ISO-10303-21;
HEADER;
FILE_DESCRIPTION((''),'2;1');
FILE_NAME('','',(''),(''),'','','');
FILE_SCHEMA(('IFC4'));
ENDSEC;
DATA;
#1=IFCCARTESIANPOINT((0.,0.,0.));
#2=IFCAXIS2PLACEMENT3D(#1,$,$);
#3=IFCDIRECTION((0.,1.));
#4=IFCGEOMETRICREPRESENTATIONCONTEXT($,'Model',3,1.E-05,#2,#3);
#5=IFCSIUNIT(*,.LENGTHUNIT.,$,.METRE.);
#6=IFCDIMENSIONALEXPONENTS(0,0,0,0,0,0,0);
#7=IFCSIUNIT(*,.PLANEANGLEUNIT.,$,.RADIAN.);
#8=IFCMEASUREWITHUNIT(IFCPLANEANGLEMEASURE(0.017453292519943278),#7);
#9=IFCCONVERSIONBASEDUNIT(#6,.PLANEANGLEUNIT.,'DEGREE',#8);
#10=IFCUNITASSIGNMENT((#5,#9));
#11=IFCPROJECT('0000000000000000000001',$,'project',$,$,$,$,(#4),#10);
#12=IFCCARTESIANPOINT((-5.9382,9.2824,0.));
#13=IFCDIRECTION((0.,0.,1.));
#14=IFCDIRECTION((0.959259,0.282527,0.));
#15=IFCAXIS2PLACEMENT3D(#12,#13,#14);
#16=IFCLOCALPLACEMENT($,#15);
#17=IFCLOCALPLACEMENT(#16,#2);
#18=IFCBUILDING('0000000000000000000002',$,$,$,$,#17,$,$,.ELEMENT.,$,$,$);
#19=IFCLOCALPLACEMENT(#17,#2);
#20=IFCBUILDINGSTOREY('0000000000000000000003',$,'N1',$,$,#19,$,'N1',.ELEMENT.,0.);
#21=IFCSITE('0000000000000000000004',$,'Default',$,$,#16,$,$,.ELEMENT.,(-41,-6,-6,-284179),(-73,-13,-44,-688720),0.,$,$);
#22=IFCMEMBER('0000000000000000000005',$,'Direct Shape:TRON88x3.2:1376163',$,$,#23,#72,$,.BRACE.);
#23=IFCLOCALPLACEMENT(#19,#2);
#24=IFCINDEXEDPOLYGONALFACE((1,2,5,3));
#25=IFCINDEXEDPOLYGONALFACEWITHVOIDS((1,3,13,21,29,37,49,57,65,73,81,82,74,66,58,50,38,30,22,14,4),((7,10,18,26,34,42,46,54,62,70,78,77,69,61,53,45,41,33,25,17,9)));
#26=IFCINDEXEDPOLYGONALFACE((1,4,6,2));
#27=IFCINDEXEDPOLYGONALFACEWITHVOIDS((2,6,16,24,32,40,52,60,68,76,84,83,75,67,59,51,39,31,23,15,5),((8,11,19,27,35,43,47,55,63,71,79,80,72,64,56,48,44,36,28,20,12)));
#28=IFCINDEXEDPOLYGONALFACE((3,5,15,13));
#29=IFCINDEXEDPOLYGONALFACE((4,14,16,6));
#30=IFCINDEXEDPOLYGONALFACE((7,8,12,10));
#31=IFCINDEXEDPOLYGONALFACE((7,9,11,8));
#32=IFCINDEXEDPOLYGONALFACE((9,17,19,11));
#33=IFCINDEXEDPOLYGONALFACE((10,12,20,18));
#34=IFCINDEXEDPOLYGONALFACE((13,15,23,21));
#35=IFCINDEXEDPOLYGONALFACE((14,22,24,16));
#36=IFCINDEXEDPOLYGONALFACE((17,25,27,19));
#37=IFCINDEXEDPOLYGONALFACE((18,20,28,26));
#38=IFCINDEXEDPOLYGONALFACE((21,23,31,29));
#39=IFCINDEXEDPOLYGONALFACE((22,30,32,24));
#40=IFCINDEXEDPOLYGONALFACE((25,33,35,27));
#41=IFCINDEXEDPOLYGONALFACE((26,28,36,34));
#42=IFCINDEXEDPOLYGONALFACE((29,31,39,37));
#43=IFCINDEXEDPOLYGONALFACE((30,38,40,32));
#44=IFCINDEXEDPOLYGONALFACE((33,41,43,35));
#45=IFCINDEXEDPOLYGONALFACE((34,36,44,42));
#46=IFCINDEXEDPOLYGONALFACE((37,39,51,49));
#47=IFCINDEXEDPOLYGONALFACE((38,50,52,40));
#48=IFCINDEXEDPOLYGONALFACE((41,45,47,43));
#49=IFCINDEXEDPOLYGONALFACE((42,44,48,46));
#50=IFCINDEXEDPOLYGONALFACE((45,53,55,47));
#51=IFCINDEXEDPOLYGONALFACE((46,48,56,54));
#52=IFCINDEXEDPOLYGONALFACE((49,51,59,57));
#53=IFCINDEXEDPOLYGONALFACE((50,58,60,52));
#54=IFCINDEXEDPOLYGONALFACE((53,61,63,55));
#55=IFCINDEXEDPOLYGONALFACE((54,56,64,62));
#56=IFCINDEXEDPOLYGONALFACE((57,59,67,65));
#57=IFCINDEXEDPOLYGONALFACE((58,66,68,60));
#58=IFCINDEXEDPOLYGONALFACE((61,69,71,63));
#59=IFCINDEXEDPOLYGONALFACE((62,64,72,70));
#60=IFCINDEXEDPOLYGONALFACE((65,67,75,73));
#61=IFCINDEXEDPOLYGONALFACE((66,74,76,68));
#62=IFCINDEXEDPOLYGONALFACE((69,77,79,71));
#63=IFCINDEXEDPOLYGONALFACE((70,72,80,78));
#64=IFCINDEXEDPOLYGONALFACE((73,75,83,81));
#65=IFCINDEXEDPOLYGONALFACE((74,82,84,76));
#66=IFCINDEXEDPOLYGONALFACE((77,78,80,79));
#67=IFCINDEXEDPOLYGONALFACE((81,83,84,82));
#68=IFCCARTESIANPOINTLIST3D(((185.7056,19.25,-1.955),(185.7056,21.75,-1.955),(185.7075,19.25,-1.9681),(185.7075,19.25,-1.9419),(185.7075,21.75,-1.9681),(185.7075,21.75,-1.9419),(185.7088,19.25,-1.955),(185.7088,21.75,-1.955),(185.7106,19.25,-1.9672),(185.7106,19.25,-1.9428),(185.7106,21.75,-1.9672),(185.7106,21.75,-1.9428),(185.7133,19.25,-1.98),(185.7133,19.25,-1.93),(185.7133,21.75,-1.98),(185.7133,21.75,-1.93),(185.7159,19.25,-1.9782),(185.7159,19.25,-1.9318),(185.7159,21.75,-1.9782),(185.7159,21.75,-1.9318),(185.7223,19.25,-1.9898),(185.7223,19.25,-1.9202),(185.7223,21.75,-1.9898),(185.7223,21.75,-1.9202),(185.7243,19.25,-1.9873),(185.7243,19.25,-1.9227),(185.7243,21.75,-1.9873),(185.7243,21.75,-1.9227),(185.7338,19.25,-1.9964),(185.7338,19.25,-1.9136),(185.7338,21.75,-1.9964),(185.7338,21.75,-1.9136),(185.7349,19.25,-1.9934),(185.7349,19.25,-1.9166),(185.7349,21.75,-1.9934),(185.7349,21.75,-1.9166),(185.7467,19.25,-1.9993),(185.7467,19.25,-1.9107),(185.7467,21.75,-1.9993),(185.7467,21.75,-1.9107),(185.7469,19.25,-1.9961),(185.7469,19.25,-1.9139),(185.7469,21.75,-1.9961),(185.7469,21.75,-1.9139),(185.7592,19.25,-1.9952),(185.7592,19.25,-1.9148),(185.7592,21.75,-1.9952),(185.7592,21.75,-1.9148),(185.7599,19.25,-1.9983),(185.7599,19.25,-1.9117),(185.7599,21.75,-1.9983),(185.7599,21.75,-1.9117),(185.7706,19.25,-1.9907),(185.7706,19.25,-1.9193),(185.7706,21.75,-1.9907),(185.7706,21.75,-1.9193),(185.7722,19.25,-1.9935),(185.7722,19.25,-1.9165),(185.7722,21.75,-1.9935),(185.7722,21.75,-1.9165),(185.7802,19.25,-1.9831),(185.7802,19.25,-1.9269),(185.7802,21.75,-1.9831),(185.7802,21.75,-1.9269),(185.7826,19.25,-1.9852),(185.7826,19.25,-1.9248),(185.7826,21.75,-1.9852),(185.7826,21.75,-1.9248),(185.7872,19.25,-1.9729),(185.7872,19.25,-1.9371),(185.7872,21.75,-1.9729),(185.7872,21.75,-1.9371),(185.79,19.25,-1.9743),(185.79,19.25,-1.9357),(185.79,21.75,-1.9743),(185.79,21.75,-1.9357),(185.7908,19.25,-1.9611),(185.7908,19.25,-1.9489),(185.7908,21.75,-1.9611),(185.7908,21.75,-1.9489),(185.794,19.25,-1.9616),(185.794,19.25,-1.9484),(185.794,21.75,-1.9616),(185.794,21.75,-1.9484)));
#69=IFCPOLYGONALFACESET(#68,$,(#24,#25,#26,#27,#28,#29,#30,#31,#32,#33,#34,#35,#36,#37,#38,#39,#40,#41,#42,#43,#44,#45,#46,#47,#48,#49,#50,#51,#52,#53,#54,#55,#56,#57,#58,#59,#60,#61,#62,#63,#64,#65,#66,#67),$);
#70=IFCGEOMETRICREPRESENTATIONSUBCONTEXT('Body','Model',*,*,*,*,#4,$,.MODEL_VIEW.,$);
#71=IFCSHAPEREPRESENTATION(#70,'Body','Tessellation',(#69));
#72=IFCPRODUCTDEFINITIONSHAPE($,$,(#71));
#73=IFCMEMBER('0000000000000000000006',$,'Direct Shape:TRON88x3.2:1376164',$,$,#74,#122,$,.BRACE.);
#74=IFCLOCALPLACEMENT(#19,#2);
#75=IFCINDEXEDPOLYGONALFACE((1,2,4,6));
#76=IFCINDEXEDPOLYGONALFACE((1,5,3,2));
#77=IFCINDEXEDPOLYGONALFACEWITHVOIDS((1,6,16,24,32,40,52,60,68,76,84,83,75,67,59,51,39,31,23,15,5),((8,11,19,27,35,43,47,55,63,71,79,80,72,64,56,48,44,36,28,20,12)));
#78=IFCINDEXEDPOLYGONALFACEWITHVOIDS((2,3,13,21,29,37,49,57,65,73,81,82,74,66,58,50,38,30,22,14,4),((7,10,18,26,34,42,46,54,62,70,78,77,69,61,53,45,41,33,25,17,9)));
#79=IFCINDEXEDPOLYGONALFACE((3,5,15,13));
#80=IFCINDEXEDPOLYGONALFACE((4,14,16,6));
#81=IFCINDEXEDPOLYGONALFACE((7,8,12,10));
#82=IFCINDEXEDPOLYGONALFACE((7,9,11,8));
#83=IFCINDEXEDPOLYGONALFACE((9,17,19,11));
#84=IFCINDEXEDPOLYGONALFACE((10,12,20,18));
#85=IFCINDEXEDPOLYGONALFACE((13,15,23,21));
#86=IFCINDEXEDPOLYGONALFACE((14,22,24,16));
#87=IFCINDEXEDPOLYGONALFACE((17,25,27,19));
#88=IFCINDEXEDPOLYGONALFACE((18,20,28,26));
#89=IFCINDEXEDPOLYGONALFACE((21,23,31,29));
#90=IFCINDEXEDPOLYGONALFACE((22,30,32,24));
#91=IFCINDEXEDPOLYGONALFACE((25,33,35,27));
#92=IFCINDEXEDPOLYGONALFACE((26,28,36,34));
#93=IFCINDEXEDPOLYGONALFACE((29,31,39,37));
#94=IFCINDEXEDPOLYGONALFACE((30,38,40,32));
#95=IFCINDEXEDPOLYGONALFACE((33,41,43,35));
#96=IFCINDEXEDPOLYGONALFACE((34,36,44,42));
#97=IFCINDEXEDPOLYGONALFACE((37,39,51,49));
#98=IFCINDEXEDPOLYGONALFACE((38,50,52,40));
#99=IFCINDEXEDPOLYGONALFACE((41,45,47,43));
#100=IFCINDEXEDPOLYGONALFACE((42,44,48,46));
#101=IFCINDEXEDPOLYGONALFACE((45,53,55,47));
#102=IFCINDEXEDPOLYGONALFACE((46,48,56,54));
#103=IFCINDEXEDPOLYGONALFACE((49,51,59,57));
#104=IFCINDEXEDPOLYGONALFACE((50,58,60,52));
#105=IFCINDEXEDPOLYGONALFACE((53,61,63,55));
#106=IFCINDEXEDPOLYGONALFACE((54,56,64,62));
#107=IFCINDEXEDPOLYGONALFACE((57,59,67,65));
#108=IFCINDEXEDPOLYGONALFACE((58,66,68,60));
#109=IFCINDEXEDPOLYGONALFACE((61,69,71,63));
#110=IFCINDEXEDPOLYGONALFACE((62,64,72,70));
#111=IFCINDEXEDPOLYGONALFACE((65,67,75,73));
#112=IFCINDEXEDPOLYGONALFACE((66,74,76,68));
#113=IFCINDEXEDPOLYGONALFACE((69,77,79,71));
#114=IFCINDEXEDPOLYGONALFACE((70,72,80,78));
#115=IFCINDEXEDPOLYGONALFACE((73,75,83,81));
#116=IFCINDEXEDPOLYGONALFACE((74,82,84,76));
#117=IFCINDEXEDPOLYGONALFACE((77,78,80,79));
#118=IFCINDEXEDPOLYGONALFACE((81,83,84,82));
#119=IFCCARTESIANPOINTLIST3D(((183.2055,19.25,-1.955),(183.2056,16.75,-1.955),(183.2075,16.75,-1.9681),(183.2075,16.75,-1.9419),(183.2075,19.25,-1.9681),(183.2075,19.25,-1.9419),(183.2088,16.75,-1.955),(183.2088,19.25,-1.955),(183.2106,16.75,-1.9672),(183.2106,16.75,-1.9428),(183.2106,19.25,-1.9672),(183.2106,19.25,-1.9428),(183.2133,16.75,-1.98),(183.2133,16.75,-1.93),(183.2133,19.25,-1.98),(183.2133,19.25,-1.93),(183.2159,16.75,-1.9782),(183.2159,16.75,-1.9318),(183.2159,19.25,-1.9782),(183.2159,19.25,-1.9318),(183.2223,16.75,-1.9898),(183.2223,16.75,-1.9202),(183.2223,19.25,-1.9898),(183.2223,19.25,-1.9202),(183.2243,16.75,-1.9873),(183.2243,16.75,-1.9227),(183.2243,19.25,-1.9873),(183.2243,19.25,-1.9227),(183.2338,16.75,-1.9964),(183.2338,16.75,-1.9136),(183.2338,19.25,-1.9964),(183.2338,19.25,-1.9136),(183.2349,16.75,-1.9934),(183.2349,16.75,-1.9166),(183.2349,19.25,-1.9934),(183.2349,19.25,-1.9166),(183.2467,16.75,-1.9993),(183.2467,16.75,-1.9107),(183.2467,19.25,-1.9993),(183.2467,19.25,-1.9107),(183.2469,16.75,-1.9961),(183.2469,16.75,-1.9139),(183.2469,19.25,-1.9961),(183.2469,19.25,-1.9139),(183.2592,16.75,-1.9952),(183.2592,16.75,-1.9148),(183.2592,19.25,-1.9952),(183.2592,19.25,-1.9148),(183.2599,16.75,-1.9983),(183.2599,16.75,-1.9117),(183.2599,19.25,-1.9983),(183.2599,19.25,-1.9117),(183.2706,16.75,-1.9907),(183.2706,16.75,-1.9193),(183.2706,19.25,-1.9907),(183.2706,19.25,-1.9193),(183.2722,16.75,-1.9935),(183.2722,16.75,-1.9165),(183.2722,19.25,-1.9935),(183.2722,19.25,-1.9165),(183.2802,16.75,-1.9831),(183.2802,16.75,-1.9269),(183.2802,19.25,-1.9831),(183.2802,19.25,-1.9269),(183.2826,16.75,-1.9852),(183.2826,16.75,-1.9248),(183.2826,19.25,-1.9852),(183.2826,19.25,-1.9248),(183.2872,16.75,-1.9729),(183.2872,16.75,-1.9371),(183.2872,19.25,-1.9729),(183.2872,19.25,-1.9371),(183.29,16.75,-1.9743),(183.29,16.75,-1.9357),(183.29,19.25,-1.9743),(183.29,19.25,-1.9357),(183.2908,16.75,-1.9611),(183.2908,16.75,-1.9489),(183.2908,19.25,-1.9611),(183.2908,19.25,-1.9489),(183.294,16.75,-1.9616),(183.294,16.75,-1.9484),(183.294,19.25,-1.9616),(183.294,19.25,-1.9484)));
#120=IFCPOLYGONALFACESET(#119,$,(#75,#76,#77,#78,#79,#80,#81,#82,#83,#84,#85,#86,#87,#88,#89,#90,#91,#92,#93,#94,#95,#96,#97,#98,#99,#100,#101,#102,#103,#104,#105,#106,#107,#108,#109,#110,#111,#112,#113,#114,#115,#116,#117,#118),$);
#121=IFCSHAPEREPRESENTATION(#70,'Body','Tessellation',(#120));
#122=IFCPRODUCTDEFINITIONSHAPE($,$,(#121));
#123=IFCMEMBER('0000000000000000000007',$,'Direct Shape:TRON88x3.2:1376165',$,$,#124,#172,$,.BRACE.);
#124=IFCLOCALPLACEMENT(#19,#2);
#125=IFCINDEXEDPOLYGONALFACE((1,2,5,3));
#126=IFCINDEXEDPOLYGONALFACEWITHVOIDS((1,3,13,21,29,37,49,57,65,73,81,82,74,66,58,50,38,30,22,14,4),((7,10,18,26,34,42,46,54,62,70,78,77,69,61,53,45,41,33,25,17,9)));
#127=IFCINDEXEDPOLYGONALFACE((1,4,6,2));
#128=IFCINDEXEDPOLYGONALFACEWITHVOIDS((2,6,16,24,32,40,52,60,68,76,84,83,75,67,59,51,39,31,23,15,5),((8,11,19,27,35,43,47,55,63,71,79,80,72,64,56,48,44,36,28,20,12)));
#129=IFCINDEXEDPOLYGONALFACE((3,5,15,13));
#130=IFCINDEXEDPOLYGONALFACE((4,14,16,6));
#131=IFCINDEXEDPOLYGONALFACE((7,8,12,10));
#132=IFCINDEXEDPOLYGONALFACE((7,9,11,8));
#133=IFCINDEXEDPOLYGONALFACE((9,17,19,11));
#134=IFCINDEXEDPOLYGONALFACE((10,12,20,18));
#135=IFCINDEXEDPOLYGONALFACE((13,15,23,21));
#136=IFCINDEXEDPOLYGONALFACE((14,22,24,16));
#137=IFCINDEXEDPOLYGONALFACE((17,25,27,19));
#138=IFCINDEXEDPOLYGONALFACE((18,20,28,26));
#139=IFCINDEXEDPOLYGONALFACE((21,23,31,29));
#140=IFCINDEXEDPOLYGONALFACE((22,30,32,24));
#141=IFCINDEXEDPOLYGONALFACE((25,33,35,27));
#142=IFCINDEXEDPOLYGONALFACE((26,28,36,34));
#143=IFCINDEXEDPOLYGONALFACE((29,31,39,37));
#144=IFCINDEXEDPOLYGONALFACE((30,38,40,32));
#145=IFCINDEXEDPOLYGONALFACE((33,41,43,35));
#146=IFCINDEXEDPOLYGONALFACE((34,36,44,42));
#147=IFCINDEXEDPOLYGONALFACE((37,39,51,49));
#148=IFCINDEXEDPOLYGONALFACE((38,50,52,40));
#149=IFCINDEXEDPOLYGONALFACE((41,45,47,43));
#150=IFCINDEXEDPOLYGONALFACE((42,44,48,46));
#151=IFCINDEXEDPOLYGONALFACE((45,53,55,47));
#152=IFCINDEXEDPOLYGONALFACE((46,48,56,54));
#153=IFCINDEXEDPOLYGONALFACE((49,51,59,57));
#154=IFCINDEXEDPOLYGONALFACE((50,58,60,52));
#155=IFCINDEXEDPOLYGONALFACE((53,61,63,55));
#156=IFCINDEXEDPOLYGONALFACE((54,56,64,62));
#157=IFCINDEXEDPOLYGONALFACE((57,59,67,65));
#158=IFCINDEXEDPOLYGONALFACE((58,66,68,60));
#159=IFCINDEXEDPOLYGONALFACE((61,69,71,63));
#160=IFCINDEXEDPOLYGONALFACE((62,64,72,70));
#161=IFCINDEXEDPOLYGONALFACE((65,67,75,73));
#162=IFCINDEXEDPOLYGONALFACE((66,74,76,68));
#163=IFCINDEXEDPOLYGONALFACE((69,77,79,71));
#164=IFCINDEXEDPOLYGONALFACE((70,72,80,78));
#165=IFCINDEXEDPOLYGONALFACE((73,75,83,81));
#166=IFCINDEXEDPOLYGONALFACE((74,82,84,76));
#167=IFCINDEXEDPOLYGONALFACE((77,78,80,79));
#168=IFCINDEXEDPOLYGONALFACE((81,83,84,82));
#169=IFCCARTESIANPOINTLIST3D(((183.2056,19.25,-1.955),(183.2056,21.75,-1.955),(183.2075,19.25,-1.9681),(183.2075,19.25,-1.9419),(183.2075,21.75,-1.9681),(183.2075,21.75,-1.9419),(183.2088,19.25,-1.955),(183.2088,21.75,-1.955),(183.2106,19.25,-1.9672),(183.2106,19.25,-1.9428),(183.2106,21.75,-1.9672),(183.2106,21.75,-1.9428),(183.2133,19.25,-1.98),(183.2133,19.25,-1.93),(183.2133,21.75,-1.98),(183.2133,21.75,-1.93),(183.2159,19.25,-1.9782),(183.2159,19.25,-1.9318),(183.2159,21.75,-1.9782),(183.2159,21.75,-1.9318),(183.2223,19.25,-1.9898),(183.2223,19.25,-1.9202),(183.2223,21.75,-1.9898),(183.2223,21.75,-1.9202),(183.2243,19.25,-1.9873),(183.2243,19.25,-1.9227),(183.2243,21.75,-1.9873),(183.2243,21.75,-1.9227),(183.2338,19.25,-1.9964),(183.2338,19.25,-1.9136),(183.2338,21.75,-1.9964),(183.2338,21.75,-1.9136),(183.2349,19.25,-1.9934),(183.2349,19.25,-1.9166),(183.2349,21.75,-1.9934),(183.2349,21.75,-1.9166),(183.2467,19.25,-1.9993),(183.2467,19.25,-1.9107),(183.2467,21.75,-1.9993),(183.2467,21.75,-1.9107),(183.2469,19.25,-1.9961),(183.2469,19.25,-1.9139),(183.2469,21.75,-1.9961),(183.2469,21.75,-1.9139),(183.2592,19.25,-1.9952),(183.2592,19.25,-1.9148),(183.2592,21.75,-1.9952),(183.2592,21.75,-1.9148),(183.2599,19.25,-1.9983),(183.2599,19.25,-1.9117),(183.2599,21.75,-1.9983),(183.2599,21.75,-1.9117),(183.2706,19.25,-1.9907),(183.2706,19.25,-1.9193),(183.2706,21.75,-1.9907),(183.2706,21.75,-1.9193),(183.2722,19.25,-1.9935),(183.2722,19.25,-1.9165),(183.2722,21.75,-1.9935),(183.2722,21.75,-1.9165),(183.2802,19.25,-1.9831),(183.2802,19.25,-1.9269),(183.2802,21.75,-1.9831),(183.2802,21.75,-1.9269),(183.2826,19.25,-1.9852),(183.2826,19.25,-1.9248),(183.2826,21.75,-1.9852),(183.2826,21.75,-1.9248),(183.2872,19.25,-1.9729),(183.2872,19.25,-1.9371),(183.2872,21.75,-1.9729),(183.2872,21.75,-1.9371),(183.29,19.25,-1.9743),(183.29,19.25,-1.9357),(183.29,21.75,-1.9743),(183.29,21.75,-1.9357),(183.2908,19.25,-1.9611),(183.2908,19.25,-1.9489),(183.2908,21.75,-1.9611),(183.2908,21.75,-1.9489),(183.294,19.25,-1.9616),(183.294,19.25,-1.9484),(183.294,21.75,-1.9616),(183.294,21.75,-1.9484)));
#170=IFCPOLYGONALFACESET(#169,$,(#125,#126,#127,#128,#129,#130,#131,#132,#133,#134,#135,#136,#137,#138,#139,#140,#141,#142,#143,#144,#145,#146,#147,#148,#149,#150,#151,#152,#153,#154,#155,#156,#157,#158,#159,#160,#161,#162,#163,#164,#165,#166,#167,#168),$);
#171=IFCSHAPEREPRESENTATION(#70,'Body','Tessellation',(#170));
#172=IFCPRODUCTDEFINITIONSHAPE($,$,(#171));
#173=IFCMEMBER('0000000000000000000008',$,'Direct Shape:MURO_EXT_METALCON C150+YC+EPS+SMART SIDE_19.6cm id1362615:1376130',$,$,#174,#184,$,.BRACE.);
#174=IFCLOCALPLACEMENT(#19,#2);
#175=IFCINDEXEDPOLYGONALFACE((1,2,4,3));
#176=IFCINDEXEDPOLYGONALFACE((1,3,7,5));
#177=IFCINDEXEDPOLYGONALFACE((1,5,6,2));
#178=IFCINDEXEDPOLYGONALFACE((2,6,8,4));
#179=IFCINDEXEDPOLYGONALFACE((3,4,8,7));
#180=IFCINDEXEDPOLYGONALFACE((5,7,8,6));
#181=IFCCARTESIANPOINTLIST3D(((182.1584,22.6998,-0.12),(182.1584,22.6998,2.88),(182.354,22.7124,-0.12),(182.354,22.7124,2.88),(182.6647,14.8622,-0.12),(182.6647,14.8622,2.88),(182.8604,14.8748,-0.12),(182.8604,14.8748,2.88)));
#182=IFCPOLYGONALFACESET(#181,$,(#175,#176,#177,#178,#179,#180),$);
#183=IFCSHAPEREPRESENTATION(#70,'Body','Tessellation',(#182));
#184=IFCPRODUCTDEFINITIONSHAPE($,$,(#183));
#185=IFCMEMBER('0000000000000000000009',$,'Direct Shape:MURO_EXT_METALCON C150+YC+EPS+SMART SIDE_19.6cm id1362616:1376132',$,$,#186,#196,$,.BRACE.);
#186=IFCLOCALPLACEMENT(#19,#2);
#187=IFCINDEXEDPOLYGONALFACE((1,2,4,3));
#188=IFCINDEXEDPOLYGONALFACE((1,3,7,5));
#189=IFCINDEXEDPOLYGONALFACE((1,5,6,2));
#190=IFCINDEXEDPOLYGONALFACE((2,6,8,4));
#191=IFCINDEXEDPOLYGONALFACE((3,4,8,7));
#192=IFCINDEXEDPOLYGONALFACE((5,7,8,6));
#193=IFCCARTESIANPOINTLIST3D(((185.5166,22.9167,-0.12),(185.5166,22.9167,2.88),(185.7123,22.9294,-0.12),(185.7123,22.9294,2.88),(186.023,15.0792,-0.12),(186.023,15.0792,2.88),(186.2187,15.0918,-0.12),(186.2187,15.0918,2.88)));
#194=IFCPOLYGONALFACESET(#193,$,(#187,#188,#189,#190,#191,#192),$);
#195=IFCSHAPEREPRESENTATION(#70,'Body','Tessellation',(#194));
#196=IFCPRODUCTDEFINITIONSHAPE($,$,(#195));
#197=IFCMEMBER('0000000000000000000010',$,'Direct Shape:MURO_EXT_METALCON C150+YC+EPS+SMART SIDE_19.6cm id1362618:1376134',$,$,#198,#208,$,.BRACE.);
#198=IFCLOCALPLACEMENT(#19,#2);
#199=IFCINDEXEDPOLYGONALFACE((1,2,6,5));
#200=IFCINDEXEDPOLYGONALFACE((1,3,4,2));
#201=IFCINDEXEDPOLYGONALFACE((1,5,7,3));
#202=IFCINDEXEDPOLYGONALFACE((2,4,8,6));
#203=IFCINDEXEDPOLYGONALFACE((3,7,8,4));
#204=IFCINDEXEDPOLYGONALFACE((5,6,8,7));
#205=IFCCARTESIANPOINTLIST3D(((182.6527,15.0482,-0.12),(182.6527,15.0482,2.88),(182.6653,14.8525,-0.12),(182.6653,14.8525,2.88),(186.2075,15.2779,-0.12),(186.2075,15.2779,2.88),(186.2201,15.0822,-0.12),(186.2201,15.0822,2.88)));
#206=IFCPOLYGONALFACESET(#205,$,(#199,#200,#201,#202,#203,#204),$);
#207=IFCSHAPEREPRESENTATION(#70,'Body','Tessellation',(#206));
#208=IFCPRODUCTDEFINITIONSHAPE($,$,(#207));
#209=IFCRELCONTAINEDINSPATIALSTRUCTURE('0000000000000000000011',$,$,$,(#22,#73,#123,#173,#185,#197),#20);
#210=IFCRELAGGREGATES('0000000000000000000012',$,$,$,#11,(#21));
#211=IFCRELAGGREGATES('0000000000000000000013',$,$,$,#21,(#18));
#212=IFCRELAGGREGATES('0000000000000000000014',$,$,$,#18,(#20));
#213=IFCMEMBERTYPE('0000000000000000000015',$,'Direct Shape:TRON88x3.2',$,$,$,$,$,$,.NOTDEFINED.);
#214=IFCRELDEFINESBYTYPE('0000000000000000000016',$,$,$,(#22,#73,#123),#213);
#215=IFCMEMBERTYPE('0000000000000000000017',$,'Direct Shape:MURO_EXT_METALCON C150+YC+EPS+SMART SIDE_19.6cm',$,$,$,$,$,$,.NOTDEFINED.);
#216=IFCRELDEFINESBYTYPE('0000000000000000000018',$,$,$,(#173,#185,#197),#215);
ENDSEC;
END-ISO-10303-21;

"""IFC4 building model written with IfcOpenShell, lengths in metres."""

from ifc_helpers import new_model, entity, si_unit, converted_unit, direction, frame, frame_2d, origin, origin_2d_with_axis, place, context, subcontext, project, spatial, rectangle, hollow_circle, extrude, type_object, element, save


model = new_model("IFC4")

# Units and contexts
model_context = context("Model", 3, precision=1e-05, world=origin(), true_north=direction((0.0, 1.0)))
body_context = subcontext(model_context, "Body", "Model", "MODEL_VIEW")
ifc_project = project(units=[si_unit("LENGTHUNIT", "METRE"), converted_unit("PLANEANGLEUNIT", "DEGREE", entity("IfcPlaneAngleMeasure", 0.017453292519943278), si_unit("PLANEANGLEUNIT", "RADIAN"), dimensions=[0, 0, 0, 0, 0, 0, 0])], contexts=[model_context])

# Site, building, storey
site_placement = place(None, frame((-5.9382, 9.2824, 0.0), z_axis=(0.0, 0.0, 1.0), x_axis=(0.959259, 0.282527, 0.0)))
site = spatial("IfcSite", under=ifc_project, at=site_placement, Name="Default", CompositionType="ELEMENT", RefLatitude=(-41, -6, -6, -284179), RefLongitude=(-73, -13, -44, -688720), RefElevation=0.0)
building_placement = place(site_placement, origin())
building = spatial("IfcBuilding", under=site, at=building_placement, CompositionType="ELEMENT")
storey_placement = place(building_placement, origin())
storey = spatial("IfcBuildingStorey", under=building, at=storey_placement, Name="N1", LongName="N1", CompositionType="ELEMENT", Elevation=0.0)

# Members
member_type_1 = type_object("IfcMemberType", Name="Direct Shape:TRON88x3.2", PredefinedType="NOTDEFINED")
member_1_placement = place(storey_placement, origin())
element("IfcMember", 1, at=member_1_placement, inside=storey, type_object=member_type_1, Name="Direct Shape:TRON88x3.2:1376163", PredefinedType="BRACE", context=body_context, shape_type="SweptSolid", body=[
    extrude(hollow_circle(Radius=0.0445, WallThickness=0.0032, at=frame_2d((0.0, 0.0), x_axis=(1.0, 0.0))), frame((185.75, 19.25, -1.955), z_axis=(0.0, 1.0, 0.0), x_axis=(-1.0, 0.0, 0.0)), (0.0, 0.0, 1.0), 2.5),
])
member_2_placement = place(storey_placement, origin())
element("IfcMember", 2, at=member_2_placement, inside=storey, type_object=member_type_1, Name="Direct Shape:TRON88x3.2:1376164", PredefinedType="BRACE", context=body_context, shape_type="SweptSolid", body=[
    extrude(hollow_circle(Radius=0.0445, WallThickness=0.0032, at=frame_2d((0.0, 0.0), x_axis=(1.0, 0.0))), frame((183.25, 16.75, -1.955), z_axis=(0.0, 1.0, 0.0), x_axis=(-1.0, 0.0, 0.0)), (0.0, 0.0, 1.0), 2.5),
])
member_3_placement = place(storey_placement, origin())
element("IfcMember", 3, at=member_3_placement, inside=storey, type_object=member_type_1, Name="Direct Shape:TRON88x3.2:1376165", PredefinedType="BRACE", context=body_context, shape_type="SweptSolid", body=[
    extrude(hollow_circle(Radius=0.0445, WallThickness=0.0032, at=frame_2d((0.0, 0.0), x_axis=(1.0, 0.0))), frame((183.25, 19.25, -1.955), z_axis=(0.0, 1.0, 0.0), x_axis=(-1.0, 0.0, 0.0)), (0.0, 0.0, 1.0), 2.5),
])
member_type_2 = type_object("IfcMemberType", Name="Direct Shape:MURO_EXT_METALCON C150+YC+EPS+SMART SIDE_19.6cm", PredefinedType="NOTDEFINED")
member_4_placement = place(storey_placement, origin())
element("IfcMember", 4, at=member_4_placement, inside=storey, type_object=member_type_2, Name="Direct Shape:MURO_EXT_METALCON C150+YC+EPS+SMART SIDE_19.6cm id1362615:1376130", PredefinedType="BRACE", context=body_context, shape_type="SweptSolid", body=[
    extrude(rectangle(XDim=0.1961, YDim=7.8539, at=origin_2d_with_axis()), frame((182.5094, 18.7873, -0.12), z_axis=(0.0, 0.0, 1.0), x_axis=(0.99792, 0.064471, 0.0)), (0.0, 0.0, 1.0), 3.0),
])
member_5_placement = place(storey_placement, origin())
element("IfcMember", 5, at=member_5_placement, inside=storey, type_object=member_type_2, Name="Direct Shape:MURO_EXT_METALCON C150+YC+EPS+SMART SIDE_19.6cm id1362616:1376132", PredefinedType="BRACE", context=body_context, shape_type="SweptSolid", body=[
    extrude(rectangle(XDim=0.1961, YDim=7.8539, at=origin_2d_with_axis()), frame((185.8677, 19.0043, -0.12), z_axis=(0.0, 0.0, 1.0), x_axis=(0.99792, 0.064471, 0.0)), (0.0, 0.0, 1.0), 3.0),
])
member_6_placement = place(storey_placement, origin())
element("IfcMember", 6, at=member_6_placement, inside=storey, type_object=member_type_2, Name="Direct Shape:MURO_EXT_METALCON C150+YC+EPS+SMART SIDE_19.6cm id1362618:1376134", PredefinedType="BRACE", context=body_context, shape_type="SweptSolid", body=[
    extrude(rectangle(XDim=0.1961, YDim=3.5622, at=frame_2d((0.0, 0.0), x_axis=(1.0, 0.0))), frame((184.4364, 15.0652, -0.12), z_axis=(0.0, 0.0, 1.0), x_axis=(-0.064471, 0.99792, 0.0)), (0.0, 0.0, 1.0), 3.0),
])

save(model, "model.ifc")
